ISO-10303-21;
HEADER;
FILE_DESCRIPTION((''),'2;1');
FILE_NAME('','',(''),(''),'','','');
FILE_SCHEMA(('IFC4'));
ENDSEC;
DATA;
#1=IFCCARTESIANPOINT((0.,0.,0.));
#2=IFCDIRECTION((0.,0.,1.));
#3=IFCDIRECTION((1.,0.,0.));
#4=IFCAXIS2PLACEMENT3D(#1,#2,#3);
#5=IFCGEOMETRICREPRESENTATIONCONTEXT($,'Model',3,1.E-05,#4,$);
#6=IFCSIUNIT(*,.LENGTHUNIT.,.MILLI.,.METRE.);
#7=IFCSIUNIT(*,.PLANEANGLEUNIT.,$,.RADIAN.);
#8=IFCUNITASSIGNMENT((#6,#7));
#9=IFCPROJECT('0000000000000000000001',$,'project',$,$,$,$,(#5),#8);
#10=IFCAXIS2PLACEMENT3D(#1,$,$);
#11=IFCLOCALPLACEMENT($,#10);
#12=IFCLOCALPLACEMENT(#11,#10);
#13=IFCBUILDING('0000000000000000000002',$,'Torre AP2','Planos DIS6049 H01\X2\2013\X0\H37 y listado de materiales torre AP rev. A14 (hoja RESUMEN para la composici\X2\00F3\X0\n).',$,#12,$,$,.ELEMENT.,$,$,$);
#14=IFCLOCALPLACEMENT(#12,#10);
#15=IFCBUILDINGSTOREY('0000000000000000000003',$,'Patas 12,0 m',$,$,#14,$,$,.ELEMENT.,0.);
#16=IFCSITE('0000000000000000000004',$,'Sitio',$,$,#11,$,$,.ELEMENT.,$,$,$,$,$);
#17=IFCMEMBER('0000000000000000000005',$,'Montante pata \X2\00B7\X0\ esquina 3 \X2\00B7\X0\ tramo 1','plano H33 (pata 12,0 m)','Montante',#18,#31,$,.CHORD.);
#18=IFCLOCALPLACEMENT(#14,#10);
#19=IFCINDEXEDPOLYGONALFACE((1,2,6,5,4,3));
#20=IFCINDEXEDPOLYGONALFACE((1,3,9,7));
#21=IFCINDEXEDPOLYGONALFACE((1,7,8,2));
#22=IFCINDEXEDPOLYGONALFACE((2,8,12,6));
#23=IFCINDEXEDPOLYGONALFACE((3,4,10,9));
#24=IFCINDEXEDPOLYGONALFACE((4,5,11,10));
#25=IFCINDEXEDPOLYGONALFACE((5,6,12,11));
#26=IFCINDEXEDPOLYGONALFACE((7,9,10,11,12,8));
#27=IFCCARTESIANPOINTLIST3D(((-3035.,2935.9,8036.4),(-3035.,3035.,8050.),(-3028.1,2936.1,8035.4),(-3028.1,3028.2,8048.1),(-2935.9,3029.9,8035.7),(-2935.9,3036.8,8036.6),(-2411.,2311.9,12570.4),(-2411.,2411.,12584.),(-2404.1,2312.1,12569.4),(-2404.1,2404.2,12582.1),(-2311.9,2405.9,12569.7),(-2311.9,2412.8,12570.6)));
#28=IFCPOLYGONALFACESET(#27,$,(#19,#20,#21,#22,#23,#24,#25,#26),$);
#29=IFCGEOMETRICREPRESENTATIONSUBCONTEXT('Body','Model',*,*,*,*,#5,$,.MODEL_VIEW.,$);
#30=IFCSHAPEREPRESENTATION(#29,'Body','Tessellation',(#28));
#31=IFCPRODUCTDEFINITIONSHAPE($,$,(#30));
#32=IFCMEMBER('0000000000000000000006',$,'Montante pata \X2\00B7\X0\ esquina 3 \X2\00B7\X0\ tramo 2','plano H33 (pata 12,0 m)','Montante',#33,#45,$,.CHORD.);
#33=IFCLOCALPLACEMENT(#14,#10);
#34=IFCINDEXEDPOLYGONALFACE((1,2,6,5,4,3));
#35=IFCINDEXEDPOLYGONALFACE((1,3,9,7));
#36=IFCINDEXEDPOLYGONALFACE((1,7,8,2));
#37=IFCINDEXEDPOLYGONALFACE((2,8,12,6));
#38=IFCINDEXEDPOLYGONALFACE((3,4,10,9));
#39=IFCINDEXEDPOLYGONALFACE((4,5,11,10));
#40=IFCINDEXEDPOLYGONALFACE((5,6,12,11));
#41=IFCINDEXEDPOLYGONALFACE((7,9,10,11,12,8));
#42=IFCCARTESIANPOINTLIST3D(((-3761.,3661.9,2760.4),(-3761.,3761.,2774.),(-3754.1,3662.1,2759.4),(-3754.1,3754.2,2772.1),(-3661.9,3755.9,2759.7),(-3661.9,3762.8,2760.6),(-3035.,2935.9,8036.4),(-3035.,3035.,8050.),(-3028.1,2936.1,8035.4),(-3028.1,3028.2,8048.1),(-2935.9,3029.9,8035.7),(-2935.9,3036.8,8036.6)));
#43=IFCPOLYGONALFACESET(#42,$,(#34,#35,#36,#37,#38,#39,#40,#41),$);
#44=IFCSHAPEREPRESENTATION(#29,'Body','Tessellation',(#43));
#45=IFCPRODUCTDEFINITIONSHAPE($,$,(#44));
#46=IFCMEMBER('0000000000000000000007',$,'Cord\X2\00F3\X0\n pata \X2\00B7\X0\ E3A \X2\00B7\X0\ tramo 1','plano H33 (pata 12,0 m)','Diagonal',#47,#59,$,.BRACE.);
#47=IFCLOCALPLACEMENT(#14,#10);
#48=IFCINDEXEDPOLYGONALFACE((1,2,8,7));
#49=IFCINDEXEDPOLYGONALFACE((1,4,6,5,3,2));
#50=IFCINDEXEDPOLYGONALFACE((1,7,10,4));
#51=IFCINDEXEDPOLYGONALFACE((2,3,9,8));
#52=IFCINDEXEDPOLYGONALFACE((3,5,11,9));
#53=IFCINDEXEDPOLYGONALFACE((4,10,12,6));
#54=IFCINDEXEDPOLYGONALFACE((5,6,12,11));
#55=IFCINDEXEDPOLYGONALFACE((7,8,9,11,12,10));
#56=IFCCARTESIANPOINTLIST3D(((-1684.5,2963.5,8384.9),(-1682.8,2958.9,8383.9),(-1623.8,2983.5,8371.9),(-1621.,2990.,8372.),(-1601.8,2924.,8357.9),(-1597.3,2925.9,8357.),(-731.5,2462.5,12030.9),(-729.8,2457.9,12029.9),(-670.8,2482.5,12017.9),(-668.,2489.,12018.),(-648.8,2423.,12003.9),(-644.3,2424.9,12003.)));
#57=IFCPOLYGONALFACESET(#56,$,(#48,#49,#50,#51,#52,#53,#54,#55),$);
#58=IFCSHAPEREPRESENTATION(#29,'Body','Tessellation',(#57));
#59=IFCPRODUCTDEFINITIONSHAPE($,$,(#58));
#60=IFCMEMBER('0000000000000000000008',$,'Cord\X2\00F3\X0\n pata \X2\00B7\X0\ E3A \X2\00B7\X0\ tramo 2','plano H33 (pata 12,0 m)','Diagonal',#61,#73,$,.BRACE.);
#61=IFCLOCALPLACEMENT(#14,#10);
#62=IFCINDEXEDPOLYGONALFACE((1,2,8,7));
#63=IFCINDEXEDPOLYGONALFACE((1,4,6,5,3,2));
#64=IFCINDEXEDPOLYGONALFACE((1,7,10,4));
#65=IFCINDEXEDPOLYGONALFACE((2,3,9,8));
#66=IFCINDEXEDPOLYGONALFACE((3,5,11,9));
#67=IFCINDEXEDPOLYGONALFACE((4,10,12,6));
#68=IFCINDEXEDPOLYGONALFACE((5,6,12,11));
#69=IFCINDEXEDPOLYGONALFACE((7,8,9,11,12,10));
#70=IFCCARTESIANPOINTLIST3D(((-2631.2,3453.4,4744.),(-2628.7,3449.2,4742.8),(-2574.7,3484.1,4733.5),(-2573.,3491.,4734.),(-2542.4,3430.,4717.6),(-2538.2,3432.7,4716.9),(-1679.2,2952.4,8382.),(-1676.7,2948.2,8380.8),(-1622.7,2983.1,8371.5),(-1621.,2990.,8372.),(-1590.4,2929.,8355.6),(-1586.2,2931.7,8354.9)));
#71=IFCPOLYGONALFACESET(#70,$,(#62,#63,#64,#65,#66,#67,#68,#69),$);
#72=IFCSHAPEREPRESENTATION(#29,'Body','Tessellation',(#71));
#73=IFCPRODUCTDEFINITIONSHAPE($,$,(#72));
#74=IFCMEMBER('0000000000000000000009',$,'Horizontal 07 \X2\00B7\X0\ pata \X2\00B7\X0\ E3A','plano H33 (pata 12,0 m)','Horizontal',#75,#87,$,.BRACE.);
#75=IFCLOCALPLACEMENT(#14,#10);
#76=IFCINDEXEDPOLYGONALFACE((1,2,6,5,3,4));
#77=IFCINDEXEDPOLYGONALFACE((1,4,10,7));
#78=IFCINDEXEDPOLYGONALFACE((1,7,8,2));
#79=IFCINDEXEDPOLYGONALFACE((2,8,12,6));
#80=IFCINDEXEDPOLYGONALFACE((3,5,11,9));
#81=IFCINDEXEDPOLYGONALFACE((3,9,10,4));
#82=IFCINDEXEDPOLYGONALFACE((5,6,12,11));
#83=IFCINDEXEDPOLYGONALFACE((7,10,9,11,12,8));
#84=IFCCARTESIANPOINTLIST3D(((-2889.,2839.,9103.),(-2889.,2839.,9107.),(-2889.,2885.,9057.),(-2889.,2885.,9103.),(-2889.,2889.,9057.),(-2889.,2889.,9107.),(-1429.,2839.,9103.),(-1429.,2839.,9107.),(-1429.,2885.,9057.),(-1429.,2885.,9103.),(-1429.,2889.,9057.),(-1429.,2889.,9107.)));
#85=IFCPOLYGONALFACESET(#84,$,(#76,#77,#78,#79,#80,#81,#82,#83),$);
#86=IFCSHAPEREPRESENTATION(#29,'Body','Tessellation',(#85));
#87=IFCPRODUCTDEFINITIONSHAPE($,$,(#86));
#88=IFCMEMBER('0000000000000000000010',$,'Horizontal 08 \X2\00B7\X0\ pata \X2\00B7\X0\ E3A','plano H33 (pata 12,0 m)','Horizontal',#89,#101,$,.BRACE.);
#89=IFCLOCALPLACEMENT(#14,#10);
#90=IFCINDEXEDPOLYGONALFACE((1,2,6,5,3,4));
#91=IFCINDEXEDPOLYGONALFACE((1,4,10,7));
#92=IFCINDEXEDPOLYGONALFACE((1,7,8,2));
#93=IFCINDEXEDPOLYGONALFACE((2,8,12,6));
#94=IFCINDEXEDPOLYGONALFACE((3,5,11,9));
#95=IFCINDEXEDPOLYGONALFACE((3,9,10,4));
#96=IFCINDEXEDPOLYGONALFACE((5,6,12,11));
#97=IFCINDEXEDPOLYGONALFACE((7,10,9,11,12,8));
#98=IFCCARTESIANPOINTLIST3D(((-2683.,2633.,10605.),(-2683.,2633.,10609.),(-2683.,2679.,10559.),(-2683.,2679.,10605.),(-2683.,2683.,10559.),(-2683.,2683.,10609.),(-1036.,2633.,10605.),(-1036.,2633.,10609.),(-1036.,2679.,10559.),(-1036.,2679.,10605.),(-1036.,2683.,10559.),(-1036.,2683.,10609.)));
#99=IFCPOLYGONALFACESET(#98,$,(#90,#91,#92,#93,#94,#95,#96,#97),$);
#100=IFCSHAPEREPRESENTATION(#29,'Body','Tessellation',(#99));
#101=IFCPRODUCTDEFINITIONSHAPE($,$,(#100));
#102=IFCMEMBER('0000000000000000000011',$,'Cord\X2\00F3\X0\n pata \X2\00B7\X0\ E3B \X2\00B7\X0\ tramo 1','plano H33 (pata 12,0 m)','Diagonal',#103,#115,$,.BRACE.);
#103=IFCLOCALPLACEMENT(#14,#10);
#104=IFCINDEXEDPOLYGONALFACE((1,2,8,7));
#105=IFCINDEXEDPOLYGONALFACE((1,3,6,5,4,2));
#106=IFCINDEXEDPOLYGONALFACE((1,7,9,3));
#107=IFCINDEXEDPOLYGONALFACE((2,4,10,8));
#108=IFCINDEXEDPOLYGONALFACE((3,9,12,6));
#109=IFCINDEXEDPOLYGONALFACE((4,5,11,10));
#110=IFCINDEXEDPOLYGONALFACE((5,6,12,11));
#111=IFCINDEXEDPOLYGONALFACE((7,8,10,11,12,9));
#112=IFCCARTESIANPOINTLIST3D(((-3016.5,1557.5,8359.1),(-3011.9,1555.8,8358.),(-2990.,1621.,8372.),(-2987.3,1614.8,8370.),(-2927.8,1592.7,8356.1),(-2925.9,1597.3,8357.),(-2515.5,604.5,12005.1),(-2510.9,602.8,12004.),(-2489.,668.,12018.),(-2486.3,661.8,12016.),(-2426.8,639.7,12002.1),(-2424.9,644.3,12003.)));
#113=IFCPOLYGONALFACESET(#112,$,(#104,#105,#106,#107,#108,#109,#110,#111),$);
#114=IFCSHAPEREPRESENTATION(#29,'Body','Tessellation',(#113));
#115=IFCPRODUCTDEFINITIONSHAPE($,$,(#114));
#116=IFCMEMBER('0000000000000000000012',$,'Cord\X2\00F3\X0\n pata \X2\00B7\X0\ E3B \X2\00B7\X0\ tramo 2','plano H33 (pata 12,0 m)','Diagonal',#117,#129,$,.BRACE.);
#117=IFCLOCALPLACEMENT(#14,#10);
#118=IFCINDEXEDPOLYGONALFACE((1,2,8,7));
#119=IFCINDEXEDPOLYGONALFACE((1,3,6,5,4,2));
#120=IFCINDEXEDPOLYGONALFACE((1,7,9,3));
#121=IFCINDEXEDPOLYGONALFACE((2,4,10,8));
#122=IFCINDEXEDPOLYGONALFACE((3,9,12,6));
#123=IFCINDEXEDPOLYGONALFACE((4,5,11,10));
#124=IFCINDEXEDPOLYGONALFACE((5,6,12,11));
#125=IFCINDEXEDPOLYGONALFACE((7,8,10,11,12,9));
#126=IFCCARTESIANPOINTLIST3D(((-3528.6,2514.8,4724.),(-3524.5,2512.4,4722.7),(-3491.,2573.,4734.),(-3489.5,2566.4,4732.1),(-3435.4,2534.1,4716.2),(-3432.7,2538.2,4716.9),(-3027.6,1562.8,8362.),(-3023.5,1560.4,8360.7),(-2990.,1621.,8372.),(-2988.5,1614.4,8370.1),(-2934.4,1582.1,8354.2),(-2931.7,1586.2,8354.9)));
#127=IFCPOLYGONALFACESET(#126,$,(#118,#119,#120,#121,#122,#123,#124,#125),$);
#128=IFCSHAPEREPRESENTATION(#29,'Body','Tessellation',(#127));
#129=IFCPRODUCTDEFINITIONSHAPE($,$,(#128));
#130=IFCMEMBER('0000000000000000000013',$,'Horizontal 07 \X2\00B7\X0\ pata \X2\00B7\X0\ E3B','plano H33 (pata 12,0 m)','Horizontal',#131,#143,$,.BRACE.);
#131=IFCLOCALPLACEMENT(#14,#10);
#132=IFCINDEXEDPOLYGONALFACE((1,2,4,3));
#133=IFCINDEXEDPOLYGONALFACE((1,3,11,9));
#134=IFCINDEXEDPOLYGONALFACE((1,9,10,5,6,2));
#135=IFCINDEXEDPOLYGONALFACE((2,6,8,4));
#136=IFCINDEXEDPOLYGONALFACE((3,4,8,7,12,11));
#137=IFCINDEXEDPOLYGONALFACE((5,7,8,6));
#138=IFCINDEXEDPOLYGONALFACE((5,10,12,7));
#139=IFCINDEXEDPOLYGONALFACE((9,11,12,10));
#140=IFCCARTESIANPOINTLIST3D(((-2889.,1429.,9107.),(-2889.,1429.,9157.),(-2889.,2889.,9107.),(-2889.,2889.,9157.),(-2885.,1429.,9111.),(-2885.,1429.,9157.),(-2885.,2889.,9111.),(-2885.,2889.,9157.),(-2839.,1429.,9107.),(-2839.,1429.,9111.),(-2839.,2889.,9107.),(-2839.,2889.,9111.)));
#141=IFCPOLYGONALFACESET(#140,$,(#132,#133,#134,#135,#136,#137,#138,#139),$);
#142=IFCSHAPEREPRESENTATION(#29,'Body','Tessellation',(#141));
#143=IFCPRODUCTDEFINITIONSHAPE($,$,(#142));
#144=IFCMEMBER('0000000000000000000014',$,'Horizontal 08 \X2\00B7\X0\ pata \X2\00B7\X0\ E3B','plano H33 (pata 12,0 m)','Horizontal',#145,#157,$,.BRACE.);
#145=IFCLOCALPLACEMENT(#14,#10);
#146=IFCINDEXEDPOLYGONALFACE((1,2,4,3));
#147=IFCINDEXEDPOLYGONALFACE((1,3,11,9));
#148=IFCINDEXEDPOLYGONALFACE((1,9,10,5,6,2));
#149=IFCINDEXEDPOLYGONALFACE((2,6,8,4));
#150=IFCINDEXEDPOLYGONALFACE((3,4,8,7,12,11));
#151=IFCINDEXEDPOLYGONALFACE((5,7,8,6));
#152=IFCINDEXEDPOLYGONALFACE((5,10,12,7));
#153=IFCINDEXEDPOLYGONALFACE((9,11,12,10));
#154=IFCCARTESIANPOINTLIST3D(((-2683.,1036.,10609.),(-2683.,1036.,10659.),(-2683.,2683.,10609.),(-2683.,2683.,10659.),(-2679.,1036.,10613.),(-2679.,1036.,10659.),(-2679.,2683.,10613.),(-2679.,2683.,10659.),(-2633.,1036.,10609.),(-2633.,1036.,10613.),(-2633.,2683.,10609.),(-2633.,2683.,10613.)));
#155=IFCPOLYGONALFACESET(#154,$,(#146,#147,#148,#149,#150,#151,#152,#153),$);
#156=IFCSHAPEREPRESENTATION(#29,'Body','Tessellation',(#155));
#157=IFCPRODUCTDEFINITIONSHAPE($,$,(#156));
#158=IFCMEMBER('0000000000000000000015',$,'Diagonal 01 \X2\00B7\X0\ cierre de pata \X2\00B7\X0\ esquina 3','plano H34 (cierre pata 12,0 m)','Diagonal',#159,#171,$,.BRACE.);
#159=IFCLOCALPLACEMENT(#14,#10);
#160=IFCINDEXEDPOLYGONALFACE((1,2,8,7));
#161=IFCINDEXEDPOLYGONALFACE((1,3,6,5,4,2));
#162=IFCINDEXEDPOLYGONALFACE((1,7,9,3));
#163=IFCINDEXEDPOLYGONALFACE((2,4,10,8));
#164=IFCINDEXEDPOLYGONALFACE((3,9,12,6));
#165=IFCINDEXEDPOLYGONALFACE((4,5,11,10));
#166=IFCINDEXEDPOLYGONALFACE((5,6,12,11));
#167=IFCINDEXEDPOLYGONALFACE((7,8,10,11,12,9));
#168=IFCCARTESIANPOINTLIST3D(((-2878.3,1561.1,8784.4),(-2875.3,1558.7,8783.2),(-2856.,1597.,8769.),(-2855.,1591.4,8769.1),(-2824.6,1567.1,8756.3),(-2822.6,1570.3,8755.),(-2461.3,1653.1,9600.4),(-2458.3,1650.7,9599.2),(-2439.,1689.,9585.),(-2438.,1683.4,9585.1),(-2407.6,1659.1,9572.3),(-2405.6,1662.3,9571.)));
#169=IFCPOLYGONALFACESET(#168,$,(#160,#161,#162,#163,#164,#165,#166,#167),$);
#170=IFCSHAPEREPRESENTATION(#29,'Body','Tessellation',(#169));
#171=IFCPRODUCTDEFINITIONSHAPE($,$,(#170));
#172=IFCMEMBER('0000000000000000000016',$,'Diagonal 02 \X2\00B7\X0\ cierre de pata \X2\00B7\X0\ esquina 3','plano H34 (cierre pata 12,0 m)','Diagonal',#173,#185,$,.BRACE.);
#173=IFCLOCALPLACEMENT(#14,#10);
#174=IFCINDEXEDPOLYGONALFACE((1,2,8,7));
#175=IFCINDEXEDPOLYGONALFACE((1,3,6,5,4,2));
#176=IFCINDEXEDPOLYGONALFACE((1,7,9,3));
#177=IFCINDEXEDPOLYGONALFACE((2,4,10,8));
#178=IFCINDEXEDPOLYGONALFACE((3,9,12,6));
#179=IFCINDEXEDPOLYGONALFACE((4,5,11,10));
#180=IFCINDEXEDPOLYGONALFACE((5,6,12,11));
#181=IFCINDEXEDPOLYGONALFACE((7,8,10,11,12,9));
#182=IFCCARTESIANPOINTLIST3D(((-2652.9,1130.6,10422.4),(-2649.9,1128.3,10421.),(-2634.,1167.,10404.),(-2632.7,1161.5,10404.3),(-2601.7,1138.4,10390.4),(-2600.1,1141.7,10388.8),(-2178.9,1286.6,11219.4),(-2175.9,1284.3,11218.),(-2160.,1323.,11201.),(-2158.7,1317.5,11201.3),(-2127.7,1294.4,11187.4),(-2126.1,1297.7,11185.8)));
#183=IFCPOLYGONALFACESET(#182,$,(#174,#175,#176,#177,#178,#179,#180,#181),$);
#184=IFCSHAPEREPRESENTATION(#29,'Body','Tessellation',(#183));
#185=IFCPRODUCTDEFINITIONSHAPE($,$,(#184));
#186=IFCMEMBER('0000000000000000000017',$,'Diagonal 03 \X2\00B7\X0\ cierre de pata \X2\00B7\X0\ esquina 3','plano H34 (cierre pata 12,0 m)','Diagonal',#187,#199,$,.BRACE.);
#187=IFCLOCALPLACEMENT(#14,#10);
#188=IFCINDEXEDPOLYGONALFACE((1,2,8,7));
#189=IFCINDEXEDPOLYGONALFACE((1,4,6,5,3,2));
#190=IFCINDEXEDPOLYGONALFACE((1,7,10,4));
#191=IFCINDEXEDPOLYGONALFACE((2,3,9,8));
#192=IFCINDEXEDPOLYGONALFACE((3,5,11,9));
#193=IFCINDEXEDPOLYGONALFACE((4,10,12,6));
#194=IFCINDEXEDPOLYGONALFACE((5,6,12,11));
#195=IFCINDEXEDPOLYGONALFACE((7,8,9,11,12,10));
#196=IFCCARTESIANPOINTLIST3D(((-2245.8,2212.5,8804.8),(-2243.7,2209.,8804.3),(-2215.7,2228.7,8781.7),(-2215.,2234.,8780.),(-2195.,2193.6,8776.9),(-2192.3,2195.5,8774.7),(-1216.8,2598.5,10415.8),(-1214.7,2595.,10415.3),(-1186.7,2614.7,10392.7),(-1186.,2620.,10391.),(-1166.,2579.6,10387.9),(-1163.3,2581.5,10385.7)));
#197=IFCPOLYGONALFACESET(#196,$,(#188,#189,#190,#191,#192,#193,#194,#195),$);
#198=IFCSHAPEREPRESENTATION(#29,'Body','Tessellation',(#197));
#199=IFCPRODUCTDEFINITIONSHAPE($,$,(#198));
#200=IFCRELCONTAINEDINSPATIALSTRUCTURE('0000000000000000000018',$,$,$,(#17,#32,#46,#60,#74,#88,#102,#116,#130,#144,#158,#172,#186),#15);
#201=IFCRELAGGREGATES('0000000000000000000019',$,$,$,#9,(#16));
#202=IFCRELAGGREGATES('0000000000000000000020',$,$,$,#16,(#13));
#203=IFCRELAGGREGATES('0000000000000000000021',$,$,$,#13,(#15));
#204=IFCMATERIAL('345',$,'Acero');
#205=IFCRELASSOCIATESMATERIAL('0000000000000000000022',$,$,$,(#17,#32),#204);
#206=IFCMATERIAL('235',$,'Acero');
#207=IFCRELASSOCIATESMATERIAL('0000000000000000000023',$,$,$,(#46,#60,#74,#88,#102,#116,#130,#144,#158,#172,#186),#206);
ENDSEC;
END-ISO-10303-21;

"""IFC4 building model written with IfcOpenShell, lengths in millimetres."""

from ifc_helpers import new_model, si_unit, frame, frame_2d, origin, origin_with_axes, place, context, subcontext, project, spatial, l_section, extrude, material, element, save


model = new_model("IFC4")

# Units and contexts
model_context = context("Model", 3, precision=1e-05, world=origin_with_axes())
body_context = subcontext(model_context, "Body", "Model", "MODEL_VIEW")
ifc_project = project(units=[si_unit("LENGTHUNIT", "METRE", prefix="MILLI"), si_unit("PLANEANGLEUNIT", "RADIAN")], contexts=[model_context])

# Site, building, storey
site_placement = place(None, origin())
site = spatial("IfcSite", under=ifc_project, at=site_placement, Name="Sitio", CompositionType="ELEMENT")
building_placement = place(site_placement, origin())
building = spatial("IfcBuilding", under=site, at=building_placement, Name="Torre AP2", Description="Planos DIS6049 H01–H37 y listado de materiales torre AP rev. A14 (hoja RESUMEN para la composición).", CompositionType="ELEMENT")
storey_placement = place(building_placement, origin())
storey = spatial("IfcBuildingStorey", under=building, at=storey_placement, Name="Patas 12,0 m", CompositionType="ELEMENT", Elevation=0.0)

# Members
ifc_material_1 = material(Name="345", Category="Acero")
member_1_placement = place(storey_placement, frame((-2411.0, 2411.0, 12584.0), z_axis=(-0.135092, 0.135092, -0.981581), x_axis=(0.990833, 0.018419, -0.13383)))
element("IfcMember", 1, at=member_1_placement, inside=storey, material=ifc_material_1, Name="Montante pata · esquina 3 · tramo 1", Description="plano H33 (pata 12,0 m)", ObjectType="Montante", PredefinedType="CHORD", context=body_context, shape_type="SweptSolid", body=[
    extrude(l_section(Depth=100.0, Width=100.0, Thickness=7.0, at=frame_2d((50.0, 50.0))), None, (0.0, 0.0, 1.0), 4619.1),
])
member_2_placement = place(storey_placement, frame((-3035.0, 3035.0, 8050.0), z_axis=(-0.13507, 0.13507, -0.981586), x_axis=(0.990836, 0.018413, -0.13381)))
element("IfcMember", 2, at=member_2_placement, inside=storey, material=ifc_material_1, Name="Montante pata · esquina 3 · tramo 2", Description="plano H33 (pata 12,0 m)", ObjectType="Montante", PredefinedType="CHORD", context=body_context, shape_type="SweptSolid", body=[
    extrude(l_section(Depth=100.0, Width=100.0, Thickness=7.0, at=frame_2d((50.0, 50.0))), None, (0.0, 0.0, 1.0), 5375.0),
])
ifc_material_2 = material(Name="235", Category="Acero")
member_3_placement = place(storey_placement, frame((-668.0, 2489.0, 12018.0), z_axis=(-0.250681, 0.131785, -0.959058), x_axis=(0.338951, -0.916032, -0.214469)))
element("IfcMember", 3, at=member_3_placement, inside=storey, material=ifc_material_2, Name="Cordón pata · E3A · tramo 1", Description="plano H33 (pata 12,0 m)", ObjectType="Diagonal", PredefinedType="BRACE", context=body_context, shape_type="SweptSolid", body=[
    extrude(l_section(Depth=70.0, Width=70.0, Thickness=5.0, at=frame_2d((35.0, 35.0))), None, (0.0, 0.0, 1.0), 3801.6),
])
member_4_placement = place(storey_placement, frame((-1621.0, 2990.0, 8372.0), z_axis=(-0.250941, 0.13206, -0.958952), x_axis=(0.49667, -0.832746, -0.24465)))
element("IfcMember", 4, at=member_4_placement, inside=storey, material=ifc_material_2, Name="Cordón pata · E3A · tramo 2", Description="plano H33 (pata 12,0 m)", ObjectType="Diagonal", PredefinedType="BRACE", context=body_context, shape_type="SweptSolid", body=[
    extrude(l_section(Depth=70.0, Width=70.0, Thickness=5.0, at=frame_2d((35.0, 35.0))), None, (0.0, 0.0, 1.0), 3793.7),
])
member_5_placement = place(storey_placement, frame((-2889.0, 2889.0, 9107.0), z_axis=(1.0, 0.0, 0.0), x_axis=(0.0, -1.0, 0.0)))
element("IfcMember", 5, at=member_5_placement, inside=storey, material=ifc_material_2, Name="Horizontal 07 · pata · E3A", Description="plano H33 (pata 12,0 m)", ObjectType="Horizontal", PredefinedType="BRACE", context=body_context, shape_type="SweptSolid", body=[
    extrude(l_section(Depth=50.0, Width=50.0, Thickness=4.0, at=frame_2d((25.0, 25.0))), None, (0.0, 0.0, 1.0), 1460.0),
])
member_6_placement = place(storey_placement, frame((-2683.0, 2683.0, 10609.0), z_axis=(1.0, 0.0, 0.0), x_axis=(0.0, -1.0, 0.0)))
element("IfcMember", 6, at=member_6_placement, inside=storey, material=ifc_material_2, Name="Horizontal 08 · pata · E3A", Description="plano H33 (pata 12,0 m)", ObjectType="Horizontal", PredefinedType="BRACE", context=body_context, shape_type="SweptSolid", body=[
    extrude(l_section(Depth=50.0, Width=50.0, Thickness=4.0, at=frame_2d((25.0, 25.0))), None, (0.0, 0.0, 1.0), 1647.0),
])
member_7_placement = place(storey_placement, frame((-2489.0, 668.0, 12018.0), z_axis=(-0.131785, 0.250681, -0.959058), x_axis=(0.916032, -0.338951, -0.214469)))
element("IfcMember", 7, at=member_7_placement, inside=storey, material=ifc_material_2, Name="Cordón pata · E3B · tramo 1", Description="plano H33 (pata 12,0 m)", ObjectType="Diagonal", PredefinedType="BRACE", context=body_context, shape_type="SweptSolid", body=[
    extrude(l_section(Depth=70.0, Width=70.0, Thickness=5.0, at=frame_2d((35.0, 35.0))), None, (0.0, 0.0, 1.0), 3801.6),
])
member_8_placement = place(storey_placement, frame((-2990.0, 1621.0, 8372.0), z_axis=(-0.13206, 0.250941, -0.958952), x_axis=(0.832746, -0.49667, -0.24465)))
element("IfcMember", 8, at=member_8_placement, inside=storey, material=ifc_material_2, Name="Cordón pata · E3B · tramo 2", Description="plano H33 (pata 12,0 m)", ObjectType="Diagonal", PredefinedType="BRACE", context=body_context, shape_type="SweptSolid", body=[
    extrude(l_section(Depth=70.0, Width=70.0, Thickness=5.0, at=frame_2d((35.0, 35.0))), None, (0.0, 0.0, 1.0), 3793.7),
])
member_9_placement = place(storey_placement, frame((-2889.0, 2889.0, 9107.0), z_axis=(0.0, -1.0, 0.0), x_axis=(1.0, 0.0, 0.0)))
element("IfcMember", 9, at=member_9_placement, inside=storey, material=ifc_material_2, Name="Horizontal 07 · pata · E3B", Description="plano H33 (pata 12,0 m)", ObjectType="Horizontal", PredefinedType="BRACE", context=body_context, shape_type="SweptSolid", body=[
    extrude(l_section(Depth=50.0, Width=50.0, Thickness=4.0, at=frame_2d((25.0, 25.0))), None, (0.0, 0.0, 1.0), 1460.0),
])
member_10_placement = place(storey_placement, frame((-2683.0, 2683.0, 10609.0), z_axis=(0.0, -1.0, 0.0), x_axis=(1.0, 0.0, 0.0)))
element("IfcMember", 10, at=member_10_placement, inside=storey, material=ifc_material_2, Name="Horizontal 08 · pata · E3B", Description="plano H33 (pata 12,0 m)", ObjectType="Horizontal", PredefinedType="BRACE", context=body_context, shape_type="SweptSolid", body=[
    extrude(l_section(Depth=50.0, Width=50.0, Thickness=4.0, at=frame_2d((25.0, 25.0))), None, (0.0, 0.0, 1.0), 1647.0),
])
member_11_placement = place(storey_placement, frame((-2439.0, 1689.0, 9585.0), z_axis=(-0.452777, -0.099893, -0.88601), x_axis=(0.741403, -0.594179, -0.311888)))
element("IfcMember", 11, at=member_11_placement, inside=storey, material=ifc_material_2, Name="Diagonal 01 · cierre de pata · esquina 3", Description="plano H34 (cierre pata 12,0 m)", ObjectType="Diagonal", PredefinedType="BRACE", context=body_context, shape_type="SweptSolid", body=[
    extrude(l_section(Depth=45.0, Width=45.0, Thickness=4.0, at=frame_2d((22.5, 22.5))), None, (0.0, 0.0, 1.0), 921.0),
])
member_12_placement = place(storey_placement, frame((-2160.0, 1323.0, 11201.0), z_axis=(-0.504078, -0.165899, -0.847575), x_axis=(0.754279, -0.56258, -0.338477)))
element("IfcMember", 12, at=member_12_placement, inside=storey, material=ifc_material_2, Name="Diagonal 02 · cierre de pata · esquina 3", Description="plano H34 (cierre pata 12,0 m)", ObjectType="Diagonal", PredefinedType="BRACE", context=body_context, shape_type="SweptSolid", body=[
    extrude(l_section(Depth=45.0, Width=45.0, Thickness=4.0, at=frame_2d((22.5, 22.5))), None, (0.0, 0.0, 1.0), 940.3),
])
member_13_placement = place(storey_placement, frame((-1186.0, 2620.0, 10391.0), z_axis=(-0.527647, -0.197932, -0.826082), x_axis=(0.504616, -0.855328, -0.117376)))
element("IfcMember", 13, at=member_13_placement, inside=storey, material=ifc_material_2, Name="Diagonal 03 · cierre de pata · esquina 3", Description="plano H34 (cierre pata 12,0 m)", ObjectType="Diagonal", PredefinedType="BRACE", context=body_context, shape_type="SweptSolid", body=[
    extrude(l_section(Depth=45.0, Width=45.0, Thickness=4.0, at=frame_2d((22.5, 22.5))), None, (0.0, 0.0, 1.0), 1950.2),
])

save(model, "model.ifc")
